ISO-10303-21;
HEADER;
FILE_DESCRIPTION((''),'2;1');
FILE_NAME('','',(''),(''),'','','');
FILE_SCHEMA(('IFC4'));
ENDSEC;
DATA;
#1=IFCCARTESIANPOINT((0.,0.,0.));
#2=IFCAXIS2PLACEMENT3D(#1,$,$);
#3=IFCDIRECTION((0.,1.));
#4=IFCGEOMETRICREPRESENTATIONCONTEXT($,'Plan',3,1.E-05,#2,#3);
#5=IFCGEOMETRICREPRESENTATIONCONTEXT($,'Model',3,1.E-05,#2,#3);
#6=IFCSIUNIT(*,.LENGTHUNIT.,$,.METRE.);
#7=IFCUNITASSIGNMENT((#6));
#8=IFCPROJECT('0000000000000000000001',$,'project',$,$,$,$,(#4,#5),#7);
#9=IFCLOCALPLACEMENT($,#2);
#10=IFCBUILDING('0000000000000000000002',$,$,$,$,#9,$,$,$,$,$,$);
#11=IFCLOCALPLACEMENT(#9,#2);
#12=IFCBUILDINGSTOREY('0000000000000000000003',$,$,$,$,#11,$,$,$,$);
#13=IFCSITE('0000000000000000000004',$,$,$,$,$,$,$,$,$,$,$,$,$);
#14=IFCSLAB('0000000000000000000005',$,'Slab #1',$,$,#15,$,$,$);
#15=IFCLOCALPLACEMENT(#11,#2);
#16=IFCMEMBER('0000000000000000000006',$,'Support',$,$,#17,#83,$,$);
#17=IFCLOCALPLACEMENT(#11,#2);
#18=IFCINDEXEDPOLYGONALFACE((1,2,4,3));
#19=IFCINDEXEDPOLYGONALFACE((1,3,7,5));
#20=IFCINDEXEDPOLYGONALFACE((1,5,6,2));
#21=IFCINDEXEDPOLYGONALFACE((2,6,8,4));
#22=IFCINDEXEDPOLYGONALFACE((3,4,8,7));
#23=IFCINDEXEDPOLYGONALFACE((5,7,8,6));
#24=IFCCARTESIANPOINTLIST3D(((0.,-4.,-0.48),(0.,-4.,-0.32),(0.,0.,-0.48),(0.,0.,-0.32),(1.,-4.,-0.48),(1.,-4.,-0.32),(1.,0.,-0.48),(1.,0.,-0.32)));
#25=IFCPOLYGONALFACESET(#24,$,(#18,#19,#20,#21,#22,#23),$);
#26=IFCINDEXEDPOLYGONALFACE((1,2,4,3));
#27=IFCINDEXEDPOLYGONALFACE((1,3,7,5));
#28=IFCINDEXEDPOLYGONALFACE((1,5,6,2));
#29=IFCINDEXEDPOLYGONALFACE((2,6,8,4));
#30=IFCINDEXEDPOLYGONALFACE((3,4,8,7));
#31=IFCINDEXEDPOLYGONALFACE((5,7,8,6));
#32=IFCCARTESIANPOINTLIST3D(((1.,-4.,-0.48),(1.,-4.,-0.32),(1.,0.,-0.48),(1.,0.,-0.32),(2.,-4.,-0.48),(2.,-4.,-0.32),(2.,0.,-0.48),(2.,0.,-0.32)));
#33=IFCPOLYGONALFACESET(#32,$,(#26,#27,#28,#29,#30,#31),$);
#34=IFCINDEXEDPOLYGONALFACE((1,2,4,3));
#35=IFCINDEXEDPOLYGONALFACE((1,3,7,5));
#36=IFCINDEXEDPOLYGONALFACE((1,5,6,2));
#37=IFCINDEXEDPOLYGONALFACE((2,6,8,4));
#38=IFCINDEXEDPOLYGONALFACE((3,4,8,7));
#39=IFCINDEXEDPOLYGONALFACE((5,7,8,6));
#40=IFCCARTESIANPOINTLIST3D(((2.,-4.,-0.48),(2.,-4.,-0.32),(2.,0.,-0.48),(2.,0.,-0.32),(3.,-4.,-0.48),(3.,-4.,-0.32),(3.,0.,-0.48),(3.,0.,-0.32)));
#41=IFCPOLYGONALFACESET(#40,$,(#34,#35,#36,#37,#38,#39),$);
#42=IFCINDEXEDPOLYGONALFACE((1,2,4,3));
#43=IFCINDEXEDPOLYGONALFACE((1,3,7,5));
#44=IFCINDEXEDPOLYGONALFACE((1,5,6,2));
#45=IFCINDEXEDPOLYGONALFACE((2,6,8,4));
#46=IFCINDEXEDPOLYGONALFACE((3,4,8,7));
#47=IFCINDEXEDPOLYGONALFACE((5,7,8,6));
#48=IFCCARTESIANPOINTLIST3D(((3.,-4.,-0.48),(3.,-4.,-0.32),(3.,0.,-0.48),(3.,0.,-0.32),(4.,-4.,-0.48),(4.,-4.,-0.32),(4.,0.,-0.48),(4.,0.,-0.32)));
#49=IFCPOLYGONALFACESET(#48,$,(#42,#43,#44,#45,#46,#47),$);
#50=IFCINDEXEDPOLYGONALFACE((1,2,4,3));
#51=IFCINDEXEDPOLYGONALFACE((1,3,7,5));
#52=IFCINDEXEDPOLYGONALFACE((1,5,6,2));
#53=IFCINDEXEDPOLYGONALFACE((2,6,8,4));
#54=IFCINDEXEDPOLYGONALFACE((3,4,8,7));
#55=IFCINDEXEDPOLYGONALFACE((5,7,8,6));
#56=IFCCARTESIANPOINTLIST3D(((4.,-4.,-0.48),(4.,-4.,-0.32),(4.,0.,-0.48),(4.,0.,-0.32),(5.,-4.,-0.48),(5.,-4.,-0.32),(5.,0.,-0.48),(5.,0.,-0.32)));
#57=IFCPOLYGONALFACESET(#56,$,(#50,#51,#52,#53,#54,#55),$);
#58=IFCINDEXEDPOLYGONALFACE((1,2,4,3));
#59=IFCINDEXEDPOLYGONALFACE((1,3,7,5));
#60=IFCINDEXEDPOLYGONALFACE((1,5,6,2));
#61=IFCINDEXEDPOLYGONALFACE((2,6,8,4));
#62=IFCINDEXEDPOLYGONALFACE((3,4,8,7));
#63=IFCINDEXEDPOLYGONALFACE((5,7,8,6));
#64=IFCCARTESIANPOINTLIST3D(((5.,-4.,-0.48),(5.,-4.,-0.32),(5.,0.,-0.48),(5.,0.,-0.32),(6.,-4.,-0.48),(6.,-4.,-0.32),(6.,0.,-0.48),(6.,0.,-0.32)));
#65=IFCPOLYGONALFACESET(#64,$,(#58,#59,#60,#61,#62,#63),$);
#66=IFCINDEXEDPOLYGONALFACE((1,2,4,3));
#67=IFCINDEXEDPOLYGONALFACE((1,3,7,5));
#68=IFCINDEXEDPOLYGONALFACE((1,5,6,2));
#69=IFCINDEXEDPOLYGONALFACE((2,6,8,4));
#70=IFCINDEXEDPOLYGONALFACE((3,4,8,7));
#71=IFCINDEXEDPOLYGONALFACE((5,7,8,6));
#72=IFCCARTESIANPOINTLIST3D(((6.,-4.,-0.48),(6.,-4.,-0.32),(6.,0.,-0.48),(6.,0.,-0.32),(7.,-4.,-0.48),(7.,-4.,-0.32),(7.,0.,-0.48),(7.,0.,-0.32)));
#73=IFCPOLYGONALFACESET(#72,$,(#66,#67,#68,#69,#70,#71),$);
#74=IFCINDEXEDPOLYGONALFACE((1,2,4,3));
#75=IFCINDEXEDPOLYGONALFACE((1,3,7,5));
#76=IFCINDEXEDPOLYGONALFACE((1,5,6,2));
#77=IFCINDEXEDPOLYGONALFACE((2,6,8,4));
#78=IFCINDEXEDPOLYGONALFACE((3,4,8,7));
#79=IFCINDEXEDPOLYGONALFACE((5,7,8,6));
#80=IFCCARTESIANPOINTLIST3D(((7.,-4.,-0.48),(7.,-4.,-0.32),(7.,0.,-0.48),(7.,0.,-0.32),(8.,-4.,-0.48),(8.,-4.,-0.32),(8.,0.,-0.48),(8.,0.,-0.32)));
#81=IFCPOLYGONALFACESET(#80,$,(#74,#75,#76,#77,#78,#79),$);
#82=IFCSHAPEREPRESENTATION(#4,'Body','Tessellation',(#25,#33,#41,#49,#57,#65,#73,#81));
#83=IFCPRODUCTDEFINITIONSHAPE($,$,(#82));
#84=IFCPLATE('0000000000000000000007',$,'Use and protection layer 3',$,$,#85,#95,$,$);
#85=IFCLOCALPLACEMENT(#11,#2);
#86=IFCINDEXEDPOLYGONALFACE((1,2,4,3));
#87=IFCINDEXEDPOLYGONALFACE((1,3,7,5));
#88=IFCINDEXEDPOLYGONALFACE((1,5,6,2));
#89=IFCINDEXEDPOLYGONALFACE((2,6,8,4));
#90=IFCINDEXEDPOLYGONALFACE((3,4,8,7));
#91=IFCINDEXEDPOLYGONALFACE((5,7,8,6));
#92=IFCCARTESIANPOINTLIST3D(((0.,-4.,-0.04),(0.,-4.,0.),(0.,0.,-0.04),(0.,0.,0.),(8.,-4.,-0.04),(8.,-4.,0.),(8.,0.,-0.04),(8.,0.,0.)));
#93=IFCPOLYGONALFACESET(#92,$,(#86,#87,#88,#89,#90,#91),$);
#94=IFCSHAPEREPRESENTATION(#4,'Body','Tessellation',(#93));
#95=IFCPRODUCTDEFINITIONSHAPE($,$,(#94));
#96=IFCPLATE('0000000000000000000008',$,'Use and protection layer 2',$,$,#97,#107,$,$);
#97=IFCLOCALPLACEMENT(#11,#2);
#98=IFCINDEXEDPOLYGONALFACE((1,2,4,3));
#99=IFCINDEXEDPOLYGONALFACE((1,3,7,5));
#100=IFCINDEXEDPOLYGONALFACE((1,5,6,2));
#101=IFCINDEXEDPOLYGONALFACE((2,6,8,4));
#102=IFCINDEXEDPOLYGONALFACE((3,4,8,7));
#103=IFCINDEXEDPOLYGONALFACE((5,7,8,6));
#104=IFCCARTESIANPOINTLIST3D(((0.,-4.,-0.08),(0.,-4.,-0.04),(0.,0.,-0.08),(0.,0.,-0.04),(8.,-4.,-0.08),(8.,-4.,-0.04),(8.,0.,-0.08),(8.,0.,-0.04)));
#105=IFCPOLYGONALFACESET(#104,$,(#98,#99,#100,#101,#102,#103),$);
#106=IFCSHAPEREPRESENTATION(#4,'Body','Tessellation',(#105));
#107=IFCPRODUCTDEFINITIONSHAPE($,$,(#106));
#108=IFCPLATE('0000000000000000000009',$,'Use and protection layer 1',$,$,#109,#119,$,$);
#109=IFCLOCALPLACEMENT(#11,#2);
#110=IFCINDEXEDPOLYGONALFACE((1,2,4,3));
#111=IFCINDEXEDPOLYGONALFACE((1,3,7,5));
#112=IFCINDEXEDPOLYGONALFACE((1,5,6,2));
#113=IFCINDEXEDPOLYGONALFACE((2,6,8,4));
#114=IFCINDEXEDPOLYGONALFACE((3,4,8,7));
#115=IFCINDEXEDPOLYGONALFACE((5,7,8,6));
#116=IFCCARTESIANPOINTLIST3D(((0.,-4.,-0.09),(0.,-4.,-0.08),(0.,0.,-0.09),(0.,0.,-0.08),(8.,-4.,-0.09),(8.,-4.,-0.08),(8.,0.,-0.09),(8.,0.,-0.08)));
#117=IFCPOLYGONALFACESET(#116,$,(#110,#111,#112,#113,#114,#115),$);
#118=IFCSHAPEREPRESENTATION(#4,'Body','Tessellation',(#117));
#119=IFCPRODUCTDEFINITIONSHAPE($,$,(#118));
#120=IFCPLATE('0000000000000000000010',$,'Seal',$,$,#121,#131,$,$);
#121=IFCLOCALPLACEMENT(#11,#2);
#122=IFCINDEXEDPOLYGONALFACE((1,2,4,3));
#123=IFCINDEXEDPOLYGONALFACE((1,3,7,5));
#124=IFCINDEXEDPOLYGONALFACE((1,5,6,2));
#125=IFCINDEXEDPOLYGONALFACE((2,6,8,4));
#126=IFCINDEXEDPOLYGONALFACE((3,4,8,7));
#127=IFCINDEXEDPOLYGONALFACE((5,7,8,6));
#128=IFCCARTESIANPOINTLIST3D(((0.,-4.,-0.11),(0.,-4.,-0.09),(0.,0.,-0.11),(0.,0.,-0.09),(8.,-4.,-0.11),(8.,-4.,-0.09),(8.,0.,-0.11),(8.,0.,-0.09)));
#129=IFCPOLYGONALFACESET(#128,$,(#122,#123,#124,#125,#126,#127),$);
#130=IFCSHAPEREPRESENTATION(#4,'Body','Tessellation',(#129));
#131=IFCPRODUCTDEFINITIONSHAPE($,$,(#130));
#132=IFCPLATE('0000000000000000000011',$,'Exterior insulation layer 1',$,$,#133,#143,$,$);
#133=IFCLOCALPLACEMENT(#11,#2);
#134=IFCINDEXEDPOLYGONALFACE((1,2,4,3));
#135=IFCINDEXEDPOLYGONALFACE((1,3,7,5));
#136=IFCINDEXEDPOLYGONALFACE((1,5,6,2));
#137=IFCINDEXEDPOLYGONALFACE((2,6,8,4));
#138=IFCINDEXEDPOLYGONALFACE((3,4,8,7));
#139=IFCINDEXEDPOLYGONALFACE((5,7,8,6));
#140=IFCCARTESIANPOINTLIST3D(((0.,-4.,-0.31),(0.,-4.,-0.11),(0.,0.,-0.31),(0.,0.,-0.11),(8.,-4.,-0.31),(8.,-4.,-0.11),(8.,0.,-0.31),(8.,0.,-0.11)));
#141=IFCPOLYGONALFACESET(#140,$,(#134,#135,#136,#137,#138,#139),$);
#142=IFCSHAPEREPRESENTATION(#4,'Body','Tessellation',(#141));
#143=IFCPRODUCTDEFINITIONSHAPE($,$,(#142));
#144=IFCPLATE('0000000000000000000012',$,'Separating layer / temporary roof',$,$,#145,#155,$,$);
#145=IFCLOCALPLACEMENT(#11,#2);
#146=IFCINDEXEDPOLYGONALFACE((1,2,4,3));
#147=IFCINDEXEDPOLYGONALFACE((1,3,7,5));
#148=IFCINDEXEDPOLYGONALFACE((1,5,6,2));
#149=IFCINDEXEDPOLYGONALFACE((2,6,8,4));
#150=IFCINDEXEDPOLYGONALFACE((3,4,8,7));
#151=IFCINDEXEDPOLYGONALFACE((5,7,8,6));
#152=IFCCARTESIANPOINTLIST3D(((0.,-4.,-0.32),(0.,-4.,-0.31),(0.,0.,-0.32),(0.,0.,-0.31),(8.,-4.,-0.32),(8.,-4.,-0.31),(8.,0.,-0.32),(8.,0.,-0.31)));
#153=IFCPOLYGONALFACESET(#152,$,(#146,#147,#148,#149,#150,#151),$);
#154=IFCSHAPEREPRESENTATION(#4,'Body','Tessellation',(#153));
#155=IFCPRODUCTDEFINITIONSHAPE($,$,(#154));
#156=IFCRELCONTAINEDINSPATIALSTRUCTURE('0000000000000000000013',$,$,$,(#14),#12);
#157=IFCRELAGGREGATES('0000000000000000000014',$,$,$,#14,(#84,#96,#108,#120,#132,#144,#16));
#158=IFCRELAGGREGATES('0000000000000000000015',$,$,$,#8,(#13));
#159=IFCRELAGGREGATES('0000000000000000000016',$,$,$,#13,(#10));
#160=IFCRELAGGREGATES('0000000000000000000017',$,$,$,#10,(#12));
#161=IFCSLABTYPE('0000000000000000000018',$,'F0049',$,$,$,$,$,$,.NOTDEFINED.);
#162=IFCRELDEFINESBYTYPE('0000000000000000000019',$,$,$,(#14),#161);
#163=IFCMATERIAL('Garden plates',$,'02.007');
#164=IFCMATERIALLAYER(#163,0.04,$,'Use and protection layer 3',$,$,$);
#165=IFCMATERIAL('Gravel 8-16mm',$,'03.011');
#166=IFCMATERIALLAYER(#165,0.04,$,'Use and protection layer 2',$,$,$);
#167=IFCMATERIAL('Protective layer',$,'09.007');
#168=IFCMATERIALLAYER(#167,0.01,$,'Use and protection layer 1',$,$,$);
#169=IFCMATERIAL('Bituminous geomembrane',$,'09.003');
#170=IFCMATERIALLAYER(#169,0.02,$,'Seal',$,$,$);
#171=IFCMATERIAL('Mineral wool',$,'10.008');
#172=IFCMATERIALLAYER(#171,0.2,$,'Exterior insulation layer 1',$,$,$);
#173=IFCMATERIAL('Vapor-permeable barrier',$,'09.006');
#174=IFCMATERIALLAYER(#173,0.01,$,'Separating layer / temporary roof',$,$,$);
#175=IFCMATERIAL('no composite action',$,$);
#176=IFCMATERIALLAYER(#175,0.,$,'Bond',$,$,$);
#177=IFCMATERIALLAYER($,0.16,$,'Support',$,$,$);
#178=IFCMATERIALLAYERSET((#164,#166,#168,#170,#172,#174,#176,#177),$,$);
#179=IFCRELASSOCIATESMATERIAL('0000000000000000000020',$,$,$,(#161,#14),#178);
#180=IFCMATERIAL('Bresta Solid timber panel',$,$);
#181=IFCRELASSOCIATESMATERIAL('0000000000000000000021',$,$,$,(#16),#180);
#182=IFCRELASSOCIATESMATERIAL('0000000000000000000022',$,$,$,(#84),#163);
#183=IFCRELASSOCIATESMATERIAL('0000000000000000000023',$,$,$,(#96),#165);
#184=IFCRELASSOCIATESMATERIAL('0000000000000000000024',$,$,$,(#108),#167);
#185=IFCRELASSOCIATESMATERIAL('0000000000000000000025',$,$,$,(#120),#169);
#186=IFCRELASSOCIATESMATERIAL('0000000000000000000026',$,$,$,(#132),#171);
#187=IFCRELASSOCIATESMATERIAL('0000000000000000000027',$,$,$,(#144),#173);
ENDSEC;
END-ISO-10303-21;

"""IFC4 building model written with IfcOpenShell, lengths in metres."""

from ifc_helpers import new_model, si_unit, direction, frame, frame_2d, origin, origin_with_axes, place, context, project, spatial, rectangle, extrude, material, layer, layer_set, type_object, element, aggregate, save


model = new_model("IFC4")

# Units and contexts
plan_context = context("Plan", 3, precision=1e-05, world=origin(), true_north=direction((0.0, 1.0)))
model_context = context("Model", 3, precision=1e-05, world=origin(), true_north=direction((0.0, 1.0)))
ifc_project = project(units=[si_unit("LENGTHUNIT", "METRE")], contexts=[plan_context, model_context])

# Site, building, storey
site = spatial("IfcSite", under=ifc_project)
building_placement = place(None, origin())
building = spatial("IfcBuilding", under=site, at=building_placement)
storey_placement = place(building_placement, origin())
storey = spatial("IfcBuildingStorey", under=building, at=storey_placement)

# Slab, member, plates
ifc_material_1 = material(Name="Garden plates", Category="02.007")
ifc_layer_1 = layer(ifc_material_1, 0.04, Name="Use and protection layer 3")
ifc_material_2 = material(Name="Gravel 8-16mm", Category="03.011")
ifc_layer_2 = layer(ifc_material_2, 0.04, Name="Use and protection layer 2")
ifc_material_3 = material(Name="Protective layer", Category="09.007")
ifc_layer_3 = layer(ifc_material_3, 0.01, Name="Use and protection layer 1")
ifc_material_4 = material(Name="Bituminous geomembrane", Category="09.003")
ifc_layer_4 = layer(ifc_material_4, 0.02, Name="Seal")
ifc_material_5 = material(Name="Mineral wool", Category="10.008")
ifc_layer_5 = layer(ifc_material_5, 0.2, Name="Exterior insulation layer 1")
ifc_material_6 = material(Name="Vapor-permeable barrier", Category="09.006")
ifc_layer_6 = layer(ifc_material_6, 0.01, Name="Separating layer / temporary roof")
ifc_material_7 = material(Name="no composite action")
ifc_layer_7 = layer(ifc_material_7, 0.0, Name="Bond")
ifc_layer_8 = layer(None, 0.16, Name="Support")
ifc_layer_set = layer_set([ifc_layer_1, ifc_layer_2, ifc_layer_3, ifc_layer_4, ifc_layer_5, ifc_layer_6, ifc_layer_7, ifc_layer_8])
slab_type = type_object("IfcSlabType", Name="F0049", PredefinedType="NOTDEFINED", material=ifc_layer_set)
slab_placement = place(None, frame((0.0, 0.0, 0.0), z_axis=(0.0, 0.0, -1.0), x_axis=(1.0, 0.0, 0.0)))
slab = element("IfcSlab", 1, at=slab_placement, inside=storey, type_object=slab_type, material=ifc_layer_set, Name="Slab #1")
ifc_material_8 = material(Name="Bresta Solid timber panel")
member_placement = place(slab_placement, origin())
member = element("IfcMember", 2, at=member_placement, material=ifc_material_8, Name="Support", context=plan_context, shape_type="SweptSolid", body=[
    extrude(rectangle(XDim=1.0, YDim=0.16, at=frame_2d((0.5, 0.08), x_axis=(1.0, 0.0))), frame((0.0, 4.0, 0.32), z_axis=(0.0, -1.0, 0.0), x_axis=(1.0, 0.0, 0.0)), (0.0, 0.0, 1.0), 4.0),
    extrude(rectangle(XDim=1.0, YDim=0.16, at=frame_2d((0.5, 0.08), x_axis=(1.0, 0.0))), frame((1.0, 4.0, 0.32), z_axis=(0.0, -1.0, 0.0), x_axis=(1.0, 0.0, 0.0)), (0.0, 0.0, 1.0), 4.0),
    extrude(rectangle(XDim=1.0, YDim=0.16, at=frame_2d((0.5, 0.08), x_axis=(1.0, 0.0))), frame((2.0, 4.0, 0.32), z_axis=(0.0, -1.0, 0.0), x_axis=(1.0, 0.0, 0.0)), (0.0, 0.0, 1.0), 4.0),
    extrude(rectangle(XDim=1.0, YDim=0.16, at=frame_2d((0.5, 0.08), x_axis=(1.0, 0.0))), frame((3.0, 4.0, 0.32), z_axis=(0.0, -1.0, 0.0), x_axis=(1.0, 0.0, 0.0)), (0.0, 0.0, 1.0), 4.0),
    extrude(rectangle(XDim=1.0, YDim=0.16, at=frame_2d((0.5, 0.08), x_axis=(1.0, 0.0))), frame((4.0, 4.0, 0.32), z_axis=(0.0, -1.0, 0.0), x_axis=(1.0, 0.0, 0.0)), (0.0, 0.0, 1.0), 4.0),
    extrude(rectangle(XDim=1.0, YDim=0.16, at=frame_2d((0.5, 0.08), x_axis=(1.0, 0.0))), frame((5.0, 4.0, 0.32), z_axis=(0.0, -1.0, 0.0), x_axis=(1.0, 0.0, 0.0)), (0.0, 0.0, 1.0), 4.0),
    extrude(rectangle(XDim=1.0, YDim=0.16, at=frame_2d((0.5, 0.08), x_axis=(1.0, 0.0))), frame((6.0, 4.0, 0.32), z_axis=(0.0, -1.0, 0.0), x_axis=(1.0, 0.0, 0.0)), (0.0, 0.0, 1.0), 4.0),
    extrude(rectangle(XDim=1.0, YDim=0.16, at=frame_2d((0.5, 0.08), x_axis=(1.0, 0.0))), frame((7.0, 4.0, 0.32), z_axis=(0.0, -1.0, 0.0), x_axis=(1.0, 0.0, 0.0)), (0.0, 0.0, 1.0), 4.0),
])
plate_1_placement = place(slab_placement, origin())
plate_1 = element("IfcPlate", 3, at=plate_1_placement, material=ifc_material_1, Name="Use and protection layer 3", context=plan_context, shape_type="SweptSolid", body=[
    extrude(rectangle(XDim=8.0, YDim=4.0, at=frame_2d((4.0, 2.0), x_axis=(1.0, 0.0))), origin_with_axes(), (0.0, 0.0, 1.0), 0.04),
])
plate_2_placement = place(slab_placement, origin())
plate_2 = element("IfcPlate", 4, at=plate_2_placement, material=ifc_material_2, Name="Use and protection layer 2", context=plan_context, shape_type="SweptSolid", body=[
    extrude(rectangle(XDim=8.0, YDim=4.0, at=frame_2d((4.0, 2.0), x_axis=(1.0, 0.0))), frame((0.0, 0.0, 0.04), z_axis=(0.0, 0.0, 1.0), x_axis=(1.0, 0.0, 0.0)), (0.0, 0.0, 1.0), 0.04),
])
plate_3_placement = place(slab_placement, origin())
plate_3 = element("IfcPlate", 5, at=plate_3_placement, material=ifc_material_3, Name="Use and protection layer 1", context=plan_context, shape_type="SweptSolid", body=[
    extrude(rectangle(XDim=8.0, YDim=4.0, at=frame_2d((4.0, 2.0), x_axis=(1.0, 0.0))), frame((0.0, 0.0, 0.08), z_axis=(0.0, 0.0, 1.0), x_axis=(1.0, 0.0, 0.0)), (0.0, 0.0, 1.0), 0.01),
])
plate_4_placement = place(slab_placement, origin())
plate_4 = element("IfcPlate", 6, at=plate_4_placement, material=ifc_material_4, Name="Seal", context=plan_context, shape_type="SweptSolid", body=[
    extrude(rectangle(XDim=8.0, YDim=4.0, at=frame_2d((4.0, 2.0), x_axis=(1.0, 0.0))), frame((0.0, 0.0, 0.09), z_axis=(0.0, 0.0, 1.0), x_axis=(1.0, 0.0, 0.0)), (0.0, 0.0, 1.0), 0.02),
])
plate_5_placement = place(slab_placement, origin())
plate_5 = element("IfcPlate", 7, at=plate_5_placement, material=ifc_material_5, Name="Exterior insulation layer 1", context=plan_context, shape_type="SweptSolid", body=[
    extrude(rectangle(XDim=8.0, YDim=4.0, at=frame_2d((4.0, 2.0), x_axis=(1.0, 0.0))), frame((0.0, 0.0, 0.11), z_axis=(0.0, 0.0, 1.0), x_axis=(1.0, 0.0, 0.0)), (0.0, 0.0, 1.0), 0.2),
])
plate_6_placement = place(slab_placement, origin())
plate_6 = element("IfcPlate", 8, at=plate_6_placement, material=ifc_material_6, Name="Separating layer / temporary roof", context=plan_context, shape_type="SweptSolid", body=[
    extrude(rectangle(XDim=8.0, YDim=4.0, at=frame_2d((4.0, 2.0), x_axis=(1.0, 0.0))), frame((0.0, 0.0, 0.31), z_axis=(0.0, 0.0, 1.0), x_axis=(1.0, 0.0, 0.0)), (0.0, 0.0, 1.0), 0.01),
])
aggregate(slab, [plate_1, plate_2, plate_3, plate_4, plate_5, plate_6, member])

save(model, "model.ifc")
